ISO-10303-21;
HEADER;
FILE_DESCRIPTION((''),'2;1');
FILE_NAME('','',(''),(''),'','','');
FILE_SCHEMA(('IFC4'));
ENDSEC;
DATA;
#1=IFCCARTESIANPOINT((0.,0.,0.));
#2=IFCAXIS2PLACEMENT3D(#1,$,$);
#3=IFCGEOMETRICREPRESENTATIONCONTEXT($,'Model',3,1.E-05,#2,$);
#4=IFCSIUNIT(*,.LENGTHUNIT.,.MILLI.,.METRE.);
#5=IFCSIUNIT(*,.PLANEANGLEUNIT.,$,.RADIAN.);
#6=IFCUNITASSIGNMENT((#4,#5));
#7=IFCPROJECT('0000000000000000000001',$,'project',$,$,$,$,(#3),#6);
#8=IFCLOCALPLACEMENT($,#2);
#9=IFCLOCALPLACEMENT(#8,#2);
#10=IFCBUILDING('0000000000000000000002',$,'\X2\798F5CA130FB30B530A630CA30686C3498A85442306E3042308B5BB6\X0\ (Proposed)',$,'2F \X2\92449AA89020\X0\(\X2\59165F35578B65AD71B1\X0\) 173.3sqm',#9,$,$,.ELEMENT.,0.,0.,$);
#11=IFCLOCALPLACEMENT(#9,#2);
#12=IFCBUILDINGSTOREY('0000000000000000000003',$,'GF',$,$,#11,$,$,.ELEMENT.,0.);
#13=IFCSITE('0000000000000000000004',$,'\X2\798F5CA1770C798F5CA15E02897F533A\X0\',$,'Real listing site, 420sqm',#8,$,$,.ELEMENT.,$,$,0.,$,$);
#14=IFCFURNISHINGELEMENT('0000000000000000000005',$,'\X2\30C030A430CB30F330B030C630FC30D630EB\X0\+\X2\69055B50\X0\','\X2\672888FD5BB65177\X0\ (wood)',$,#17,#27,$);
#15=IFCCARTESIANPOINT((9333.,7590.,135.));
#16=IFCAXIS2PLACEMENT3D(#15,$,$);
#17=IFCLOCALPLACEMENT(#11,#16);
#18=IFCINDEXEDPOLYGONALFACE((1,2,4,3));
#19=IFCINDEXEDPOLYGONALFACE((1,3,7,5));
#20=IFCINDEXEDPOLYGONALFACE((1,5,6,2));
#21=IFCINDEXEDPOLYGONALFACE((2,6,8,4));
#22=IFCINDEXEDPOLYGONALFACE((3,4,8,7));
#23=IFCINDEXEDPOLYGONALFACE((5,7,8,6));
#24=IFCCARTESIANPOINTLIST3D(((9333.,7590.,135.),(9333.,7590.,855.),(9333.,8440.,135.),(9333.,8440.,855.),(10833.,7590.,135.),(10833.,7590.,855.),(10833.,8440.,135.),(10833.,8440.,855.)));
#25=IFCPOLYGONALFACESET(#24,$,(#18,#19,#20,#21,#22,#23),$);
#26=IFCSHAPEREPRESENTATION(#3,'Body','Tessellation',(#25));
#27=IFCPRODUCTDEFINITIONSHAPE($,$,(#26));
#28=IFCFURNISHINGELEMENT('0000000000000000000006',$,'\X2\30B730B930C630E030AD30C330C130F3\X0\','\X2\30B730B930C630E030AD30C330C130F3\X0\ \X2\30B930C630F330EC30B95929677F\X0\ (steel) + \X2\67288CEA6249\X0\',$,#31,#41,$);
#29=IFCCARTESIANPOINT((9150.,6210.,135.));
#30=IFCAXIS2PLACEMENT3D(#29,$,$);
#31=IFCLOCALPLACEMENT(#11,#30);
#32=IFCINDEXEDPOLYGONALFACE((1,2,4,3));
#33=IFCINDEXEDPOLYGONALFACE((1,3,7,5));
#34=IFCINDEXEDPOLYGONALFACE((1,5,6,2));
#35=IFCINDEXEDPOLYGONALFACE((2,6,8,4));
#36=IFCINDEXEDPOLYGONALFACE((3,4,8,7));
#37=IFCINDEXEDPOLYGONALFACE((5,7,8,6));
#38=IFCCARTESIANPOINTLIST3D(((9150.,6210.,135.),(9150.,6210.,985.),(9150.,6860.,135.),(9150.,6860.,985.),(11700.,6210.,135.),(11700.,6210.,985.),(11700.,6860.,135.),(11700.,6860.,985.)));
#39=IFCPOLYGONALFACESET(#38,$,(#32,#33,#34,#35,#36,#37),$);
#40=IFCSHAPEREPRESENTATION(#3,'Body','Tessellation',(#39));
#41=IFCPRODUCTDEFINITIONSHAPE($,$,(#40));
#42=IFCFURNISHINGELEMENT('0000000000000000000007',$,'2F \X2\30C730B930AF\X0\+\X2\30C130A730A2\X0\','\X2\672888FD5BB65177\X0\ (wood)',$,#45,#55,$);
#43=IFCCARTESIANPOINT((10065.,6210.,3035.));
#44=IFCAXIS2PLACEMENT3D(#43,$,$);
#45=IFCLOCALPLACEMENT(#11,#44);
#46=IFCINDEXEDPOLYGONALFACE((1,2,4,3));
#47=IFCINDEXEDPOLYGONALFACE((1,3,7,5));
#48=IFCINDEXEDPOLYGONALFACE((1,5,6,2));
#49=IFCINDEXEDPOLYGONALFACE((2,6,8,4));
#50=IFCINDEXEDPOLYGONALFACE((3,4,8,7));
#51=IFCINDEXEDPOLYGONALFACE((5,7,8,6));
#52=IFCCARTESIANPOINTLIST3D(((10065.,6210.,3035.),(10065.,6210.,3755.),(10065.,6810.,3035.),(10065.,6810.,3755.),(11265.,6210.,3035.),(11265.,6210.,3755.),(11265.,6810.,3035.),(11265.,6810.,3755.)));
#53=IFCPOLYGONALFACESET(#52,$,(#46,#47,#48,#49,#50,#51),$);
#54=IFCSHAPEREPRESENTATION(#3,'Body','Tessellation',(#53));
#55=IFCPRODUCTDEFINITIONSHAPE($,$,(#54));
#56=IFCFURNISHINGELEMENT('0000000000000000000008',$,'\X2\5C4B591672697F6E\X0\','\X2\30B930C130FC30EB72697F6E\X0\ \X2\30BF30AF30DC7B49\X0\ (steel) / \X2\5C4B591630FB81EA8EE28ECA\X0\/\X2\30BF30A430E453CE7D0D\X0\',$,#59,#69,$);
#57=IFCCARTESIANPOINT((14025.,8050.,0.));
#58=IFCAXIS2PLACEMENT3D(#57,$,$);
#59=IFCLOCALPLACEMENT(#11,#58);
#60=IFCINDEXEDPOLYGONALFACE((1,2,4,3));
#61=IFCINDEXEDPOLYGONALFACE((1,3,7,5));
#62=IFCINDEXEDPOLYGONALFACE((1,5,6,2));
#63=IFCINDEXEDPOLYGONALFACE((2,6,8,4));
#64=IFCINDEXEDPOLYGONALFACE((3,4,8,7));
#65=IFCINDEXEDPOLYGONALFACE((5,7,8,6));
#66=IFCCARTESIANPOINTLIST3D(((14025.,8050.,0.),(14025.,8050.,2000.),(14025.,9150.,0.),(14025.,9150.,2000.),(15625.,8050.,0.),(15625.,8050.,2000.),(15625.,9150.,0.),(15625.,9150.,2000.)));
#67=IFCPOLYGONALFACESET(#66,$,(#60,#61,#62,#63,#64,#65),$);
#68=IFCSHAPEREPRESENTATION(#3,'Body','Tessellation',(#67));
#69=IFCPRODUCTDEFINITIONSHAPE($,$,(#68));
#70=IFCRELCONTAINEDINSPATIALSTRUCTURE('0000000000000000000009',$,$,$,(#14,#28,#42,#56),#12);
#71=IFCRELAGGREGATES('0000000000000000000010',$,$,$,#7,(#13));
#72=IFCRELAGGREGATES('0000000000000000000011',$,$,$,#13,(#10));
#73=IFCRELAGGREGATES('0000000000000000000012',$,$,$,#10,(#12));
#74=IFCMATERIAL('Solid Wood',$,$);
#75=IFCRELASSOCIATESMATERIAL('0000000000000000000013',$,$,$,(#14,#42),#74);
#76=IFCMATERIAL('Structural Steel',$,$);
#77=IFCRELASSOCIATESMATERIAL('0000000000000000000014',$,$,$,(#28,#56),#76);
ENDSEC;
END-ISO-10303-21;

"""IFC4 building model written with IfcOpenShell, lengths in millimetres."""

from ifc_helpers import new_model, si_unit, frame, frame_2d, origin, place, context, project, spatial, rectangle, extrude, material, element, save


model = new_model("IFC4")

# Units and contexts
model_context = context("Model", 3, precision=1e-05, world=origin())
ifc_project = project(units=[si_unit("LENGTHUNIT", "METRE", prefix="MILLI"), si_unit("PLANEANGLEUNIT", "RADIAN")], contexts=[model_context])

# Site, building, storey
site_placement = place(None, origin())
site = spatial("IfcSite", under=ifc_project, at=site_placement, Name="福岡県福岡市西区", ObjectType="Real listing site, 420sqm", CompositionType="ELEMENT", RefElevation=0.0)
building_placement = place(site_placement, origin())
building = spatial("IfcBuilding", under=site, at=building_placement, Name="福岡・サウナと水風呂のある家 (Proposed)", ObjectType="2F 鉄骨造(外張型断熱) 173.3sqm", CompositionType="ELEMENT", ElevationOfRefHeight=0.0, ElevationOfTerrain=0.0)
storey_placement = place(building_placement, origin())
storey = spatial("IfcBuildingStorey", under=building, at=storey_placement, Name="GF", CompositionType="ELEMENT", Elevation=0.0)

# Shared definitions
ifc_material_1 = material(Name="Solid Wood")

# Shared definitions
ifc_material_2 = material(Name="Structural Steel")

# Furnishing elements
furnishing_1_placement = place(storey_placement, frame((9333.0, 7590.0, 135.0)))
element("IfcFurnishingElement", 1, at=furnishing_1_placement, inside=storey, material=ifc_material_1, Name="ダイニングテーブル+椅子", Description="木製家具 (wood)", context=model_context, shape_type="SweptSolid", body=[
    extrude(rectangle(XDim=1500.0, YDim=850.0, at=frame_2d((750.0, 425.0))), frame((9333.0, 7590.0, 135.0)), (0.0, 0.0, 1.0), 720.0),
])
furnishing_2_placement = place(storey_placement, frame((9150.0, 6210.0, 135.0)))
element("IfcFurnishingElement", 2, at=furnishing_2_placement, inside=storey, material=ifc_material_2, Name="システムキッチン", Description="システムキッチン ステンレス天板 (steel) + 木質扉", context=model_context, shape_type="SweptSolid", body=[
    extrude(rectangle(XDim=2550.0, YDim=650.0, at=frame_2d((1275.0, 325.0))), frame((9150.0, 6210.0, 135.0)), (0.0, 0.0, 1.0), 850.0),
])
furnishing_3_placement = place(storey_placement, frame((10065.0, 6210.0, 3035.0)))
element("IfcFurnishingElement", 3, at=furnishing_3_placement, inside=storey, material=ifc_material_1, Name="2F デスク+チェア", Description="木製家具 (wood)", context=model_context, shape_type="SweptSolid", body=[
    extrude(rectangle(XDim=1200.0, YDim=600.0, at=frame_2d((600.0, 300.0))), frame((10065.0, 6210.0, 3035.0)), (0.0, 0.0, 1.0), 720.0),
])
furnishing_4_placement = place(storey_placement, frame((14025.0, 8050.0, 0.0)))
element("IfcFurnishingElement", 4, at=furnishing_4_placement, inside=storey, material=ifc_material_2, Name="屋外物置", Description="スチール物置 タクボ等 (steel) / 屋外・自転車/タイヤ収納", context=model_context, shape_type="SweptSolid", body=[
    extrude(rectangle(XDim=1600.0, YDim=1100.0, at=frame_2d((800.0, 550.0))), frame((14025.0, 8050.0, 0.0)), (0.0, 0.0, 1.0), 2000.0),
])

save(model, "model.ifc")
